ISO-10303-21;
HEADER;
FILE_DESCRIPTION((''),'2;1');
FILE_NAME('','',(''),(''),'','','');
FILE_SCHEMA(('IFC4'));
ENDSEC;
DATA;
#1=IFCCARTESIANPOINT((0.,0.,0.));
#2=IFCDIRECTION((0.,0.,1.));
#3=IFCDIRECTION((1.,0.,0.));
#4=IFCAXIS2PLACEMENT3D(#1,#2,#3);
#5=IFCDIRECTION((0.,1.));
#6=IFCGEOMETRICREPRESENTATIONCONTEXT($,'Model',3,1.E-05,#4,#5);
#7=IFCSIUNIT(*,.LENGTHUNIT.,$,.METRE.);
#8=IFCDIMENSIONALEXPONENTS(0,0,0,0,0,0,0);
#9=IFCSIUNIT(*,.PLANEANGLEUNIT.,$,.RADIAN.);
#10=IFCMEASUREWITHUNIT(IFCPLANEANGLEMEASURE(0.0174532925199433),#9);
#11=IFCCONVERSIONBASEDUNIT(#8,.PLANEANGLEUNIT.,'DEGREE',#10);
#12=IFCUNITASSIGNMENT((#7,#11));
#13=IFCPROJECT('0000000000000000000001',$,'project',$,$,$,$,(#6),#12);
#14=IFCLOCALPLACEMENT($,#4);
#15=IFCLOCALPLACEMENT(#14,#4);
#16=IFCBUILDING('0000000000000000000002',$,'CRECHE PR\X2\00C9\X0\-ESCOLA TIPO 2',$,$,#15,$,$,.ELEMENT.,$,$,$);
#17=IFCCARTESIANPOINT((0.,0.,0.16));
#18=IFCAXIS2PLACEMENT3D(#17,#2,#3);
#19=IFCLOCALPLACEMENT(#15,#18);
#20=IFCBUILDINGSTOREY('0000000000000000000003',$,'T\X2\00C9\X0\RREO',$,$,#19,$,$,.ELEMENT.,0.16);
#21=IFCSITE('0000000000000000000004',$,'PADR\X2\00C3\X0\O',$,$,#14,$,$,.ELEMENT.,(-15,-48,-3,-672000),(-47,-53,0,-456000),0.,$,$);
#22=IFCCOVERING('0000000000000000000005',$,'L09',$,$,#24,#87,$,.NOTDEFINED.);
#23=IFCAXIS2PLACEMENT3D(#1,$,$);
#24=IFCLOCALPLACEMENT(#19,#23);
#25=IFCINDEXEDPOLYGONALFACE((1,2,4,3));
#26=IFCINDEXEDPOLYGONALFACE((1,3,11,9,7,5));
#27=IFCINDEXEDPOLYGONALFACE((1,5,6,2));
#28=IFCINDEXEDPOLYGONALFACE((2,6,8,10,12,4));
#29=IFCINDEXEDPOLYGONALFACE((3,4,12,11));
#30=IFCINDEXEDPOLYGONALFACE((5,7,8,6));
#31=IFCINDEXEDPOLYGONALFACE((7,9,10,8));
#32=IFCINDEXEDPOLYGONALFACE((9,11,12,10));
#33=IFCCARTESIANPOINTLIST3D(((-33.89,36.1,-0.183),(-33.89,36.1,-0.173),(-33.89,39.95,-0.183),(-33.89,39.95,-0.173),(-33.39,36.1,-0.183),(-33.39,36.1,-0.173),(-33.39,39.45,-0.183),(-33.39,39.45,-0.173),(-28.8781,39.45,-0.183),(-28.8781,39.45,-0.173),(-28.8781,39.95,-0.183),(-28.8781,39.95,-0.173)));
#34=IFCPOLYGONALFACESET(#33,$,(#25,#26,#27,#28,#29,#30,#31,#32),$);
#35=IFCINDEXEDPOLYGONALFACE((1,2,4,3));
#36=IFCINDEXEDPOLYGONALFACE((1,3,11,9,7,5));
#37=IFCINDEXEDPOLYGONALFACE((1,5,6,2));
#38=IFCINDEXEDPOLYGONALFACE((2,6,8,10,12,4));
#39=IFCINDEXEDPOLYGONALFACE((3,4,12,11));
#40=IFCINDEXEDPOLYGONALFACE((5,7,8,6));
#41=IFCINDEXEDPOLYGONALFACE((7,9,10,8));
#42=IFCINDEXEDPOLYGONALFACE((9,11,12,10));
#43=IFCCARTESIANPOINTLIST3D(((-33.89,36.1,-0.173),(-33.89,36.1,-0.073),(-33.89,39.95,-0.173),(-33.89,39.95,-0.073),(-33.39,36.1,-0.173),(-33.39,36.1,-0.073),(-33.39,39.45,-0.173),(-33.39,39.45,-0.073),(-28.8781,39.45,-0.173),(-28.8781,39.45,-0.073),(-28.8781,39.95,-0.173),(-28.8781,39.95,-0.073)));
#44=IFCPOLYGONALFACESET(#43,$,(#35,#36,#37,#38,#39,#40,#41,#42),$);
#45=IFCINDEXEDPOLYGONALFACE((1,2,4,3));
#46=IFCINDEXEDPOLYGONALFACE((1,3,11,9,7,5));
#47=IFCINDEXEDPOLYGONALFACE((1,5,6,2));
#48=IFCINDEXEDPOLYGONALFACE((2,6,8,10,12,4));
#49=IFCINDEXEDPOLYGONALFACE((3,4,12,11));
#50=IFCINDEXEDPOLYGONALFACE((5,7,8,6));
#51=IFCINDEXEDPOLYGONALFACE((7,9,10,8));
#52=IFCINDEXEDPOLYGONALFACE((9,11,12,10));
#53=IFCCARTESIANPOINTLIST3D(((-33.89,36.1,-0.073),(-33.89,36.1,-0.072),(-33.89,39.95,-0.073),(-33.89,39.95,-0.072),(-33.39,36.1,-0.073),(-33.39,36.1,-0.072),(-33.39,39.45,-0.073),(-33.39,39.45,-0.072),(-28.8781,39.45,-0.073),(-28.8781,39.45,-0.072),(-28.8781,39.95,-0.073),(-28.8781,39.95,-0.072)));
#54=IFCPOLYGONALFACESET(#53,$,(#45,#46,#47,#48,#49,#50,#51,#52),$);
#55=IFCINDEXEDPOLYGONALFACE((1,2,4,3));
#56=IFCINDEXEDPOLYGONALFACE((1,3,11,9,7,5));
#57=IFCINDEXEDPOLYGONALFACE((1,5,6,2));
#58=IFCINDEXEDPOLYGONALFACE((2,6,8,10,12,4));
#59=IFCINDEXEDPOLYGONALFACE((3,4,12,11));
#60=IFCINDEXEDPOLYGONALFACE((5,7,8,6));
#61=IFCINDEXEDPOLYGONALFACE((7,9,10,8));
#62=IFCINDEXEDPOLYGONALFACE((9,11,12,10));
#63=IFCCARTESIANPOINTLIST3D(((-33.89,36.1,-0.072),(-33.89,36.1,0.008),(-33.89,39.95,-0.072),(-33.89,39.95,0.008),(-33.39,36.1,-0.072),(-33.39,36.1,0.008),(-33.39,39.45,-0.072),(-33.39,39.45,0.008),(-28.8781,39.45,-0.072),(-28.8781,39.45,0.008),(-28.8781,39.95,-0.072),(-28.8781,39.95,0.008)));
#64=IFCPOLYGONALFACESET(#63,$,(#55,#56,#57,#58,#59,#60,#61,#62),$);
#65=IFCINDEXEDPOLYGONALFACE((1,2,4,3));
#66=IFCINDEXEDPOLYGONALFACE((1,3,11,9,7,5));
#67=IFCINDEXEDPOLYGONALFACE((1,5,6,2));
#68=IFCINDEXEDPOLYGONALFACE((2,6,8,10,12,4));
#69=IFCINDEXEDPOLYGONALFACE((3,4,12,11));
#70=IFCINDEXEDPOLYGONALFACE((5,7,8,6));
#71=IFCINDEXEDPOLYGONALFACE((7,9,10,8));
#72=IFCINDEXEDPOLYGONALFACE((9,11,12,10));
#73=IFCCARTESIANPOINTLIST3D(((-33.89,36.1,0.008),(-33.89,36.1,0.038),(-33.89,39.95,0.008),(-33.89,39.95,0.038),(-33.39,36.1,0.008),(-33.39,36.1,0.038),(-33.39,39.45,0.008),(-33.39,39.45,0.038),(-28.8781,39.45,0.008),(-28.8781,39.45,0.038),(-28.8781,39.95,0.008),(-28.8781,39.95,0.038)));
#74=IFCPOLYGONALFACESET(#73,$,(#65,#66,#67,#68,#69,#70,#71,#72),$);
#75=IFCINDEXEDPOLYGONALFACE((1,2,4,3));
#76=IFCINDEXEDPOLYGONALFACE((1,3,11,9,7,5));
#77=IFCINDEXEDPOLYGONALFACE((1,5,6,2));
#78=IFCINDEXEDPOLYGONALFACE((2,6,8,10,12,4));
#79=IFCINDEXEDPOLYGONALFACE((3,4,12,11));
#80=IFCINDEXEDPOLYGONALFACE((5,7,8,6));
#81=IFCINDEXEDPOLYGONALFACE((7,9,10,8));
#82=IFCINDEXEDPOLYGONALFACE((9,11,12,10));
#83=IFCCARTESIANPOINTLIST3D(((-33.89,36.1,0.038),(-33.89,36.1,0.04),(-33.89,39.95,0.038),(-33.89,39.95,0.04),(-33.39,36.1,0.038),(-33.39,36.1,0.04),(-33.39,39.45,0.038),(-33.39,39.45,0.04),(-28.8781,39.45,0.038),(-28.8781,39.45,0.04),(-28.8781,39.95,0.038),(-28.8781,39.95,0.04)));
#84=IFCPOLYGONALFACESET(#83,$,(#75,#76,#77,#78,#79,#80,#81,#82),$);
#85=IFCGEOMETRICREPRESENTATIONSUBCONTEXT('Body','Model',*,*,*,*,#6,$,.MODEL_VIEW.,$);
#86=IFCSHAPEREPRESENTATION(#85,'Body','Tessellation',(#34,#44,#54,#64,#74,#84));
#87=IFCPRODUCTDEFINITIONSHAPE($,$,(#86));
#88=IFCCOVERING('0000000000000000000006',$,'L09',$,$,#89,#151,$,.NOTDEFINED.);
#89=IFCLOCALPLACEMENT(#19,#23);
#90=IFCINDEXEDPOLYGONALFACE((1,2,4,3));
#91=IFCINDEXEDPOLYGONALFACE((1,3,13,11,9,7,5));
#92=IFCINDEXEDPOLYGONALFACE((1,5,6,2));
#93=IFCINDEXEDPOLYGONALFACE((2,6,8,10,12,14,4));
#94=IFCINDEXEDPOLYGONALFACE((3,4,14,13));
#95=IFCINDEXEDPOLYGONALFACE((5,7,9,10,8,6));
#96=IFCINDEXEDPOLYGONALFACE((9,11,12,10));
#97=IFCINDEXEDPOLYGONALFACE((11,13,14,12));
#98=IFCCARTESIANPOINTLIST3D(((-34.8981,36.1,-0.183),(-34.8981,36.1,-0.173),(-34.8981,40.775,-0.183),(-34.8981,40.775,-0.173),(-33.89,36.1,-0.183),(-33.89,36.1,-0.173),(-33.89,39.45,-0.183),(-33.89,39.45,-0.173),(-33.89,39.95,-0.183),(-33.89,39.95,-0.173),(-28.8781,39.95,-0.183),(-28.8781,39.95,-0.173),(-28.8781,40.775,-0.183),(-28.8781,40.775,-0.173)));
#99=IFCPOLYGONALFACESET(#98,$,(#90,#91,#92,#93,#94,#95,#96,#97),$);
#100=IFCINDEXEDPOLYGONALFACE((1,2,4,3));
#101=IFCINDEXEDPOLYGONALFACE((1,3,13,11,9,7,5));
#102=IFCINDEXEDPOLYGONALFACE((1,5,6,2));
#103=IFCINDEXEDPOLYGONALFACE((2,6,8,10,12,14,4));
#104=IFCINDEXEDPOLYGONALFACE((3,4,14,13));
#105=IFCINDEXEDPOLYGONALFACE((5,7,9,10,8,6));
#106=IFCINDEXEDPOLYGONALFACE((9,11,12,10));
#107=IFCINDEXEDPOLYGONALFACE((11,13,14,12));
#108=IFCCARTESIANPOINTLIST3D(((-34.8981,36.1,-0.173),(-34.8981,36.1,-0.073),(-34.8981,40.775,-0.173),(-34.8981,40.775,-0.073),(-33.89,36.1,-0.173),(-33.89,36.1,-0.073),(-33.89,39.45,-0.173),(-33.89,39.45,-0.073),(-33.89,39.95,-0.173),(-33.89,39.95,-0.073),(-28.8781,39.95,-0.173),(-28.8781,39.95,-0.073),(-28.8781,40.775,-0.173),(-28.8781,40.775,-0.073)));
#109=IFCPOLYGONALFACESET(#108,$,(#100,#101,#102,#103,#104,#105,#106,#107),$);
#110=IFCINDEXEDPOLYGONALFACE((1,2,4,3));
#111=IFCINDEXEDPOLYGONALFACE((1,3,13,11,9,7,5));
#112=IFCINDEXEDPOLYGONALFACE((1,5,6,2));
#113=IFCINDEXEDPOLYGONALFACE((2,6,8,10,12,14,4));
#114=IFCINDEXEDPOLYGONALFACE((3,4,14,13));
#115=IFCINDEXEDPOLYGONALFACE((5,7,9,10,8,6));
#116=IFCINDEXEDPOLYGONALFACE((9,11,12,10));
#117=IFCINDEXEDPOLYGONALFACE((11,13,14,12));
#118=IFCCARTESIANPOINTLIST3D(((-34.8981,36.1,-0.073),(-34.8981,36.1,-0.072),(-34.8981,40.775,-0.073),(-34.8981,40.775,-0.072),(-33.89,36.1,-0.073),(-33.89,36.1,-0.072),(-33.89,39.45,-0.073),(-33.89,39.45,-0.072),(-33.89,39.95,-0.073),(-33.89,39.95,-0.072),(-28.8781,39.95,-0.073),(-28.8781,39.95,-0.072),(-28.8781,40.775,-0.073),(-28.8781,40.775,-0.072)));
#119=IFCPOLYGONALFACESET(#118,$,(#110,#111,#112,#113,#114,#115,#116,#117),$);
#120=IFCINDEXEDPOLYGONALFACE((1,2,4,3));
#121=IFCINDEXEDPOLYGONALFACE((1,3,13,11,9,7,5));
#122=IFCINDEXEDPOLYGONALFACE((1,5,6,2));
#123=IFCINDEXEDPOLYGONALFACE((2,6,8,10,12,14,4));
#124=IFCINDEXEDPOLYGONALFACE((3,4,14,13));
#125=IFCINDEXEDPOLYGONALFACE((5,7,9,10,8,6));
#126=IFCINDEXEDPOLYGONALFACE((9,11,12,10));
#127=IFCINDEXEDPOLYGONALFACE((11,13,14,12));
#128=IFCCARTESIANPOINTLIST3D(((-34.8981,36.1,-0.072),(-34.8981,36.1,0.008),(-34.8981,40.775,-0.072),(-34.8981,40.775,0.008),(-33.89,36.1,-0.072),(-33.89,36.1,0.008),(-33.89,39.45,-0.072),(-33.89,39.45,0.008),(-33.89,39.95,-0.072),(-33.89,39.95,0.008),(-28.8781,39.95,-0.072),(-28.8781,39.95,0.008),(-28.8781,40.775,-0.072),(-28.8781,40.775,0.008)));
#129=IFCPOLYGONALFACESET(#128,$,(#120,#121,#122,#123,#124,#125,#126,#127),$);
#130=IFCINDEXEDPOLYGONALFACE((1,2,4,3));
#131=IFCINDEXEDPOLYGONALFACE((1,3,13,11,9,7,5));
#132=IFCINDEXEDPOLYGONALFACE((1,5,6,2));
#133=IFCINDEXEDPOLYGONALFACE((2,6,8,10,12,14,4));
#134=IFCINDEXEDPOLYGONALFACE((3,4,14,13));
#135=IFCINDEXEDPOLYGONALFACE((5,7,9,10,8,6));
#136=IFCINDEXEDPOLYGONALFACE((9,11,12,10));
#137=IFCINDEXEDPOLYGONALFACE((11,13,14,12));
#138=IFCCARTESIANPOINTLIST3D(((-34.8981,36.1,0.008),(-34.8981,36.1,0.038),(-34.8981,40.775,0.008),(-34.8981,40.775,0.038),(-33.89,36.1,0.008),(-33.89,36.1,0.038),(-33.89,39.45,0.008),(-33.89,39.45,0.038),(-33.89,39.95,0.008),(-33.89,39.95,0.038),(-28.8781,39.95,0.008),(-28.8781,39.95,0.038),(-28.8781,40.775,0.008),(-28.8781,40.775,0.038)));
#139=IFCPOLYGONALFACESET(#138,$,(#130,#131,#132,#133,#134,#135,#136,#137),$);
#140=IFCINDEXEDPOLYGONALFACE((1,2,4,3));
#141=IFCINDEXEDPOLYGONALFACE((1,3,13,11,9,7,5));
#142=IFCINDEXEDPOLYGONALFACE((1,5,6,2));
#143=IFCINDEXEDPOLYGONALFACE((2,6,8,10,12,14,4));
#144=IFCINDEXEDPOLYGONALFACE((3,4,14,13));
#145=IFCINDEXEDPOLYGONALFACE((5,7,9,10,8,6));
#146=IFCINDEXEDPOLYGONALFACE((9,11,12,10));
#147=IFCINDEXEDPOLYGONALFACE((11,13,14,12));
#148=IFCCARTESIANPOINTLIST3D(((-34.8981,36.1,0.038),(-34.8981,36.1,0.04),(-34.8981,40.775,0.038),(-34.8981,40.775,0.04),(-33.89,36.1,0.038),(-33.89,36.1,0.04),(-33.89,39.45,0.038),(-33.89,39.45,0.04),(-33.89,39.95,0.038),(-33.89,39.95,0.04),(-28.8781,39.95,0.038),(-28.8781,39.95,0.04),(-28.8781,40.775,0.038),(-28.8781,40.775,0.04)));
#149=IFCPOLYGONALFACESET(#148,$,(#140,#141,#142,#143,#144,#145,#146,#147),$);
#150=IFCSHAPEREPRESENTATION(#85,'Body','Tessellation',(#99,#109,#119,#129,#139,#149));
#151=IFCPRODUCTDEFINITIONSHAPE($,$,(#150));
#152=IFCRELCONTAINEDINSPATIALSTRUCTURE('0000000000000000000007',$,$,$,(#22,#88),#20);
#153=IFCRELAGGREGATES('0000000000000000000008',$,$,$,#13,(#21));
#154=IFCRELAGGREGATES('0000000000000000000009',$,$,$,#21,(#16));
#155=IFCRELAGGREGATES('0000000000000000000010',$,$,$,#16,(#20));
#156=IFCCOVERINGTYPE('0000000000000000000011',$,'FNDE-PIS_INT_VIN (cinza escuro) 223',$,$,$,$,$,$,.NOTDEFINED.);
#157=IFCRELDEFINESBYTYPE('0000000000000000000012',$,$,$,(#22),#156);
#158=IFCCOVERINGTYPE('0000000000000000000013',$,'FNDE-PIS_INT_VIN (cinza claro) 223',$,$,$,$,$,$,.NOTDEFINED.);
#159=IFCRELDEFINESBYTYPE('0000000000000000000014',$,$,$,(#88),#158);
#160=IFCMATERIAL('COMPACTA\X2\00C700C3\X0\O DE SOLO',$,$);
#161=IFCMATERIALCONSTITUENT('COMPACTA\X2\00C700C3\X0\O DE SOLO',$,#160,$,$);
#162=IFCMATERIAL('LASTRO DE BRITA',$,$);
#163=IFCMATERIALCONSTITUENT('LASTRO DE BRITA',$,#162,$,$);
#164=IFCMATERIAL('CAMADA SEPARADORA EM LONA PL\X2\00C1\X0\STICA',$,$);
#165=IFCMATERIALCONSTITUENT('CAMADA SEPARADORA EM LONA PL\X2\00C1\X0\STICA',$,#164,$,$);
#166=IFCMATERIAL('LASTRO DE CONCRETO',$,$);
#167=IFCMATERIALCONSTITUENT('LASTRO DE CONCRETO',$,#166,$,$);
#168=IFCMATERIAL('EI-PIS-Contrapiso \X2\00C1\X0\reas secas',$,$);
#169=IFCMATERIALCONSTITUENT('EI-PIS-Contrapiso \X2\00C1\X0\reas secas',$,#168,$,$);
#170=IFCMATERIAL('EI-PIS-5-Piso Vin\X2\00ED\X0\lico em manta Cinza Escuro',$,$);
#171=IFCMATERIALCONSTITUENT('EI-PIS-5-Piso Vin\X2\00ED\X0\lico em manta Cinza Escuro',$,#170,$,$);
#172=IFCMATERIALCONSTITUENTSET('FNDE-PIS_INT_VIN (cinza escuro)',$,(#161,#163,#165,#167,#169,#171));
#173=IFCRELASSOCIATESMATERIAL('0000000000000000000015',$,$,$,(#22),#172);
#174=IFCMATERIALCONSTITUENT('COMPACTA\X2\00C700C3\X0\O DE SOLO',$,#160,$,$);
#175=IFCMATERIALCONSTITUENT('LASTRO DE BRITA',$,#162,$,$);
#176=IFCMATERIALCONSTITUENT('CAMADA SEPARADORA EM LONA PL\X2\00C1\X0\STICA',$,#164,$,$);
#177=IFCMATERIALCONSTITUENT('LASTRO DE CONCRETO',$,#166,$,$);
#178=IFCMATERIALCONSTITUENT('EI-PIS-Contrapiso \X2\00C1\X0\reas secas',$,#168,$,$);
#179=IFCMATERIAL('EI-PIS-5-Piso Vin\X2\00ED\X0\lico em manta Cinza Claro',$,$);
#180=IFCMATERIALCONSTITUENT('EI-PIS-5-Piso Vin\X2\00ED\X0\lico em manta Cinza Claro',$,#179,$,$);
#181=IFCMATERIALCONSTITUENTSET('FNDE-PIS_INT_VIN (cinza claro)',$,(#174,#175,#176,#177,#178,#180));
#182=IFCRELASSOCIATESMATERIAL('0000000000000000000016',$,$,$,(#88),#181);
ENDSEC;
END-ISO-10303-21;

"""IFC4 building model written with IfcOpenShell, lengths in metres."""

from ifc_helpers import new_model, entity, si_unit, converted_unit, direction, frame, origin_with_axes, place, context, subcontext, project, spatial, line, indexed_curve, outline, extrude, material, constituent, constituent_set, type_object, element, save


model = new_model("IFC4")

# Units and contexts
model_context = context("Model", 3, precision=1e-05, world=origin_with_axes(), true_north=direction((0.0, 1.0)))
body_context = subcontext(model_context, "Body", "Model", "MODEL_VIEW")
ifc_project = project(units=[si_unit("LENGTHUNIT", "METRE"), converted_unit("PLANEANGLEUNIT", "DEGREE", entity("IfcPlaneAngleMeasure", 0.0174532925199433), si_unit("PLANEANGLEUNIT", "RADIAN"), dimensions=[0, 0, 0, 0, 0, 0, 0])], contexts=[model_context])

# Site, building, storey
site_placement = place(None, origin_with_axes())
site = spatial("IfcSite", under=ifc_project, at=site_placement, Name="PADRÃO", CompositionType="ELEMENT", RefLatitude=(-15, -48, -3, -672000), RefLongitude=(-47, -53, 0, -456000), RefElevation=0.0)
building_placement = place(site_placement, origin_with_axes())
building = spatial("IfcBuilding", under=site, at=building_placement, Name="CRECHE PRÉ-ESCOLA TIPO 2", CompositionType="ELEMENT")
storey_placement = place(building_placement, frame((0.0, 0.0, 0.16), z_axis=(0.0, 0.0, 1.0), x_axis=(1.0, 0.0, 0.0)))
storey = spatial("IfcBuildingStorey", under=building, at=storey_placement, Name="TÉRREO", CompositionType="ELEMENT", Elevation=0.16)

# Coverings
ifc_material_1 = material(Name="COMPACTAÇÃO DE SOLO")
ifc_material_2 = material(Name="LASTRO DE BRITA")
ifc_constituent_1 = constituent(ifc_material_1, Name="COMPACTAÇÃO DE SOLO")
ifc_constituent_2 = constituent(ifc_material_2, Name="LASTRO DE BRITA")
ifc_material_3 = material(Name="CAMADA SEPARADORA EM LONA PLÁSTICA")
ifc_constituent_3 = constituent(ifc_material_3, Name="CAMADA SEPARADORA EM LONA PLÁSTICA")
ifc_material_4 = material(Name="LASTRO DE CONCRETO")
ifc_constituent_4 = constituent(ifc_material_4, Name="LASTRO DE CONCRETO")
ifc_material_5 = material(Name="EI-PIS-Contrapiso Áreas secas")
ifc_constituent_5 = constituent(ifc_material_5, Name="EI-PIS-Contrapiso Áreas secas")
ifc_material_6 = material(Name="EI-PIS-5-Piso Vinílico em manta Cinza Escuro")
ifc_constituent_6 = constituent(ifc_material_6, Name="EI-PIS-5-Piso Vinílico em manta Cinza Escuro")
ifc_constituent_set_1 = constituent_set(constituents=[ifc_constituent_1, ifc_constituent_2, ifc_constituent_3, ifc_constituent_4, ifc_constituent_5, ifc_constituent_6], Name="FNDE-PIS_INT_VIN (cinza escuro)")
covering_type_1 = type_object("IfcCoveringType", Name="FNDE-PIS_INT_VIN (cinza escuro) 223", PredefinedType="NOTDEFINED")
covering_1_placement = place(storey_placement, frame((-33.89, 36.1, 0.04), z_axis=(0.0, 0.0, 1.0), x_axis=(1.0, 0.0, 0.0)))
element("IfcCovering", 1, at=covering_1_placement, inside=storey, type_object=covering_type_1, material=ifc_constituent_set_1, Name="L09", PredefinedType="NOTDEFINED", context=body_context, shape_type="SweptSolid", body=[
    extrude(outline(indexed_curve([(0.0, 0.0), (0.5, 0.0), (0.5, 3.35), (5.012, 3.35), (5.012, 3.85), (0.0, 3.85)], segments=[line(1, 2, 3, 4, 5, 6, 1)])), frame((0.0, 0.0, -0.223), z_axis=(0.0, 0.0, 1.0), x_axis=(1.0, 0.0, 0.0)), (0.0, 0.0, 1.0), 0.01),
    extrude(outline(indexed_curve([(0.0, 0.0), (0.5, 0.0), (0.5, 3.35), (5.012, 3.35), (5.012, 3.85), (0.0, 3.85)], segments=[line(1, 2, 3, 4, 5, 6, 1)])), frame((0.0, 0.0, -0.213), z_axis=(0.0, 0.0, 1.0), x_axis=(1.0, 0.0, 0.0)), (0.0, 0.0, 1.0), 0.1),
    extrude(outline(indexed_curve([(0.0, 0.0), (0.5, 0.0), (0.5, 3.35), (5.012, 3.35), (5.012, 3.85), (0.0, 3.85)], segments=[line(1, 2, 3, 4, 5, 6, 1)])), frame((0.0, 0.0, -0.113), z_axis=(0.0, 0.0, 1.0), x_axis=(1.0, 0.0, 0.0)), (0.0, 0.0, 1.0), 0.001),
    extrude(outline(indexed_curve([(0.0, 0.0), (0.5, 0.0), (0.5, 3.35), (5.012, 3.35), (5.012, 3.85), (0.0, 3.85)], segments=[line(1, 2, 3, 4, 5, 6, 1)])), frame((0.0, 0.0, -0.112), z_axis=(0.0, 0.0, 1.0), x_axis=(1.0, 0.0, 0.0)), (0.0, 0.0, 1.0), 0.08),
    extrude(outline(indexed_curve([(0.0, 0.0), (0.5, 0.0), (0.5, 3.35), (5.012, 3.35), (5.012, 3.85), (0.0, 3.85)], segments=[line(1, 2, 3, 4, 5, 6, 1)])), frame((0.0, 0.0, -0.032), z_axis=(0.0, 0.0, 1.0), x_axis=(1.0, 0.0, 0.0)), (0.0, 0.0, 1.0), 0.03),
    extrude(outline(indexed_curve([(0.0, 0.0), (0.5, 0.0), (0.5, 3.35), (5.012, 3.35), (5.012, 3.85), (0.0, 3.85)], segments=[line(1, 2, 3, 4, 5, 6, 1)])), frame((0.0, 0.0, -0.002), z_axis=(0.0, 0.0, 1.0), x_axis=(1.0, 0.0, 0.0)), (0.0, 0.0, 1.0), 0.002),
])
ifc_constituent_7 = constituent(ifc_material_1, Name="COMPACTAÇÃO DE SOLO")
ifc_constituent_8 = constituent(ifc_material_2, Name="LASTRO DE BRITA")
ifc_constituent_9 = constituent(ifc_material_3, Name="CAMADA SEPARADORA EM LONA PLÁSTICA")
ifc_constituent_10 = constituent(ifc_material_4, Name="LASTRO DE CONCRETO")
ifc_constituent_11 = constituent(ifc_material_5, Name="EI-PIS-Contrapiso Áreas secas")
ifc_material_7 = material(Name="EI-PIS-5-Piso Vinílico em manta Cinza Claro")
ifc_constituent_12 = constituent(ifc_material_7, Name="EI-PIS-5-Piso Vinílico em manta Cinza Claro")
ifc_constituent_set_2 = constituent_set(constituents=[ifc_constituent_7, ifc_constituent_8, ifc_constituent_9, ifc_constituent_10, ifc_constituent_11, ifc_constituent_12], Name="FNDE-PIS_INT_VIN (cinza claro)")
covering_type_2 = type_object("IfcCoveringType", Name="FNDE-PIS_INT_VIN (cinza claro) 223", PredefinedType="NOTDEFINED")
covering_2_placement = place(storey_placement, frame((-34.8981, 36.1, 0.04), z_axis=(0.0, 0.0, 1.0), x_axis=(1.0, 0.0, 0.0)))
element("IfcCovering", 2, at=covering_2_placement, inside=storey, type_object=covering_type_2, material=ifc_constituent_set_2, Name="L09", PredefinedType="NOTDEFINED", context=body_context, shape_type="SweptSolid", body=[
    extrude(outline(indexed_curve([(0.0, 0.0), (1.008, 0.0), (1.008, 3.35), (1.008, 3.85), (6.02, 3.85), (6.02, 4.675), (0.0, 4.675)], segments=[line(1, 2, 3, 4, 5, 6, 7, 1)])), frame((0.0, 0.0, -0.223), z_axis=(0.0, 0.0, 1.0), x_axis=(1.0, 0.0, 0.0)), (0.0, 0.0, 1.0), 0.01),
    extrude(outline(indexed_curve([(0.0, 0.0), (1.008, 0.0), (1.008, 3.35), (1.008, 3.85), (6.02, 3.85), (6.02, 4.675), (0.0, 4.675)], segments=[line(1, 2, 3, 4, 5, 6, 7, 1)])), frame((0.0, 0.0, -0.213), z_axis=(0.0, 0.0, 1.0), x_axis=(1.0, 0.0, 0.0)), (0.0, 0.0, 1.0), 0.1),
    extrude(outline(indexed_curve([(0.0, 0.0), (1.008, 0.0), (1.008, 3.35), (1.008, 3.85), (6.02, 3.85), (6.02, 4.675), (0.0, 4.675)], segments=[line(1, 2, 3, 4, 5, 6, 7, 1)])), frame((0.0, 0.0, -0.113), z_axis=(0.0, 0.0, 1.0), x_axis=(1.0, 0.0, 0.0)), (0.0, 0.0, 1.0), 0.001),
    extrude(outline(indexed_curve([(0.0, 0.0), (1.008, 0.0), (1.008, 3.35), (1.008, 3.85), (6.02, 3.85), (6.02, 4.675), (0.0, 4.675)], segments=[line(1, 2, 3, 4, 5, 6, 7, 1)])), frame((0.0, 0.0, -0.112), z_axis=(0.0, 0.0, 1.0), x_axis=(1.0, 0.0, 0.0)), (0.0, 0.0, 1.0), 0.08),
    extrude(outline(indexed_curve([(0.0, 0.0), (1.008, 0.0), (1.008, 3.35), (1.008, 3.85), (6.02, 3.85), (6.02, 4.675), (0.0, 4.675)], segments=[line(1, 2, 3, 4, 5, 6, 7, 1)])), frame((0.0, 0.0, -0.032), z_axis=(0.0, 0.0, 1.0), x_axis=(1.0, 0.0, 0.0)), (0.0, 0.0, 1.0), 0.03),
    extrude(outline(indexed_curve([(0.0, 0.0), (1.008, 0.0), (1.008, 3.35), (1.008, 3.85), (6.02, 3.85), (6.02, 4.675), (0.0, 4.675)], segments=[line(1, 2, 3, 4, 5, 6, 7, 1)])), frame((0.0, 0.0, -0.002), z_axis=(0.0, 0.0, 1.0), x_axis=(1.0, 0.0, 0.0)), (0.0, 0.0, 1.0), 0.002),
])

save(model, "model.ifc")
